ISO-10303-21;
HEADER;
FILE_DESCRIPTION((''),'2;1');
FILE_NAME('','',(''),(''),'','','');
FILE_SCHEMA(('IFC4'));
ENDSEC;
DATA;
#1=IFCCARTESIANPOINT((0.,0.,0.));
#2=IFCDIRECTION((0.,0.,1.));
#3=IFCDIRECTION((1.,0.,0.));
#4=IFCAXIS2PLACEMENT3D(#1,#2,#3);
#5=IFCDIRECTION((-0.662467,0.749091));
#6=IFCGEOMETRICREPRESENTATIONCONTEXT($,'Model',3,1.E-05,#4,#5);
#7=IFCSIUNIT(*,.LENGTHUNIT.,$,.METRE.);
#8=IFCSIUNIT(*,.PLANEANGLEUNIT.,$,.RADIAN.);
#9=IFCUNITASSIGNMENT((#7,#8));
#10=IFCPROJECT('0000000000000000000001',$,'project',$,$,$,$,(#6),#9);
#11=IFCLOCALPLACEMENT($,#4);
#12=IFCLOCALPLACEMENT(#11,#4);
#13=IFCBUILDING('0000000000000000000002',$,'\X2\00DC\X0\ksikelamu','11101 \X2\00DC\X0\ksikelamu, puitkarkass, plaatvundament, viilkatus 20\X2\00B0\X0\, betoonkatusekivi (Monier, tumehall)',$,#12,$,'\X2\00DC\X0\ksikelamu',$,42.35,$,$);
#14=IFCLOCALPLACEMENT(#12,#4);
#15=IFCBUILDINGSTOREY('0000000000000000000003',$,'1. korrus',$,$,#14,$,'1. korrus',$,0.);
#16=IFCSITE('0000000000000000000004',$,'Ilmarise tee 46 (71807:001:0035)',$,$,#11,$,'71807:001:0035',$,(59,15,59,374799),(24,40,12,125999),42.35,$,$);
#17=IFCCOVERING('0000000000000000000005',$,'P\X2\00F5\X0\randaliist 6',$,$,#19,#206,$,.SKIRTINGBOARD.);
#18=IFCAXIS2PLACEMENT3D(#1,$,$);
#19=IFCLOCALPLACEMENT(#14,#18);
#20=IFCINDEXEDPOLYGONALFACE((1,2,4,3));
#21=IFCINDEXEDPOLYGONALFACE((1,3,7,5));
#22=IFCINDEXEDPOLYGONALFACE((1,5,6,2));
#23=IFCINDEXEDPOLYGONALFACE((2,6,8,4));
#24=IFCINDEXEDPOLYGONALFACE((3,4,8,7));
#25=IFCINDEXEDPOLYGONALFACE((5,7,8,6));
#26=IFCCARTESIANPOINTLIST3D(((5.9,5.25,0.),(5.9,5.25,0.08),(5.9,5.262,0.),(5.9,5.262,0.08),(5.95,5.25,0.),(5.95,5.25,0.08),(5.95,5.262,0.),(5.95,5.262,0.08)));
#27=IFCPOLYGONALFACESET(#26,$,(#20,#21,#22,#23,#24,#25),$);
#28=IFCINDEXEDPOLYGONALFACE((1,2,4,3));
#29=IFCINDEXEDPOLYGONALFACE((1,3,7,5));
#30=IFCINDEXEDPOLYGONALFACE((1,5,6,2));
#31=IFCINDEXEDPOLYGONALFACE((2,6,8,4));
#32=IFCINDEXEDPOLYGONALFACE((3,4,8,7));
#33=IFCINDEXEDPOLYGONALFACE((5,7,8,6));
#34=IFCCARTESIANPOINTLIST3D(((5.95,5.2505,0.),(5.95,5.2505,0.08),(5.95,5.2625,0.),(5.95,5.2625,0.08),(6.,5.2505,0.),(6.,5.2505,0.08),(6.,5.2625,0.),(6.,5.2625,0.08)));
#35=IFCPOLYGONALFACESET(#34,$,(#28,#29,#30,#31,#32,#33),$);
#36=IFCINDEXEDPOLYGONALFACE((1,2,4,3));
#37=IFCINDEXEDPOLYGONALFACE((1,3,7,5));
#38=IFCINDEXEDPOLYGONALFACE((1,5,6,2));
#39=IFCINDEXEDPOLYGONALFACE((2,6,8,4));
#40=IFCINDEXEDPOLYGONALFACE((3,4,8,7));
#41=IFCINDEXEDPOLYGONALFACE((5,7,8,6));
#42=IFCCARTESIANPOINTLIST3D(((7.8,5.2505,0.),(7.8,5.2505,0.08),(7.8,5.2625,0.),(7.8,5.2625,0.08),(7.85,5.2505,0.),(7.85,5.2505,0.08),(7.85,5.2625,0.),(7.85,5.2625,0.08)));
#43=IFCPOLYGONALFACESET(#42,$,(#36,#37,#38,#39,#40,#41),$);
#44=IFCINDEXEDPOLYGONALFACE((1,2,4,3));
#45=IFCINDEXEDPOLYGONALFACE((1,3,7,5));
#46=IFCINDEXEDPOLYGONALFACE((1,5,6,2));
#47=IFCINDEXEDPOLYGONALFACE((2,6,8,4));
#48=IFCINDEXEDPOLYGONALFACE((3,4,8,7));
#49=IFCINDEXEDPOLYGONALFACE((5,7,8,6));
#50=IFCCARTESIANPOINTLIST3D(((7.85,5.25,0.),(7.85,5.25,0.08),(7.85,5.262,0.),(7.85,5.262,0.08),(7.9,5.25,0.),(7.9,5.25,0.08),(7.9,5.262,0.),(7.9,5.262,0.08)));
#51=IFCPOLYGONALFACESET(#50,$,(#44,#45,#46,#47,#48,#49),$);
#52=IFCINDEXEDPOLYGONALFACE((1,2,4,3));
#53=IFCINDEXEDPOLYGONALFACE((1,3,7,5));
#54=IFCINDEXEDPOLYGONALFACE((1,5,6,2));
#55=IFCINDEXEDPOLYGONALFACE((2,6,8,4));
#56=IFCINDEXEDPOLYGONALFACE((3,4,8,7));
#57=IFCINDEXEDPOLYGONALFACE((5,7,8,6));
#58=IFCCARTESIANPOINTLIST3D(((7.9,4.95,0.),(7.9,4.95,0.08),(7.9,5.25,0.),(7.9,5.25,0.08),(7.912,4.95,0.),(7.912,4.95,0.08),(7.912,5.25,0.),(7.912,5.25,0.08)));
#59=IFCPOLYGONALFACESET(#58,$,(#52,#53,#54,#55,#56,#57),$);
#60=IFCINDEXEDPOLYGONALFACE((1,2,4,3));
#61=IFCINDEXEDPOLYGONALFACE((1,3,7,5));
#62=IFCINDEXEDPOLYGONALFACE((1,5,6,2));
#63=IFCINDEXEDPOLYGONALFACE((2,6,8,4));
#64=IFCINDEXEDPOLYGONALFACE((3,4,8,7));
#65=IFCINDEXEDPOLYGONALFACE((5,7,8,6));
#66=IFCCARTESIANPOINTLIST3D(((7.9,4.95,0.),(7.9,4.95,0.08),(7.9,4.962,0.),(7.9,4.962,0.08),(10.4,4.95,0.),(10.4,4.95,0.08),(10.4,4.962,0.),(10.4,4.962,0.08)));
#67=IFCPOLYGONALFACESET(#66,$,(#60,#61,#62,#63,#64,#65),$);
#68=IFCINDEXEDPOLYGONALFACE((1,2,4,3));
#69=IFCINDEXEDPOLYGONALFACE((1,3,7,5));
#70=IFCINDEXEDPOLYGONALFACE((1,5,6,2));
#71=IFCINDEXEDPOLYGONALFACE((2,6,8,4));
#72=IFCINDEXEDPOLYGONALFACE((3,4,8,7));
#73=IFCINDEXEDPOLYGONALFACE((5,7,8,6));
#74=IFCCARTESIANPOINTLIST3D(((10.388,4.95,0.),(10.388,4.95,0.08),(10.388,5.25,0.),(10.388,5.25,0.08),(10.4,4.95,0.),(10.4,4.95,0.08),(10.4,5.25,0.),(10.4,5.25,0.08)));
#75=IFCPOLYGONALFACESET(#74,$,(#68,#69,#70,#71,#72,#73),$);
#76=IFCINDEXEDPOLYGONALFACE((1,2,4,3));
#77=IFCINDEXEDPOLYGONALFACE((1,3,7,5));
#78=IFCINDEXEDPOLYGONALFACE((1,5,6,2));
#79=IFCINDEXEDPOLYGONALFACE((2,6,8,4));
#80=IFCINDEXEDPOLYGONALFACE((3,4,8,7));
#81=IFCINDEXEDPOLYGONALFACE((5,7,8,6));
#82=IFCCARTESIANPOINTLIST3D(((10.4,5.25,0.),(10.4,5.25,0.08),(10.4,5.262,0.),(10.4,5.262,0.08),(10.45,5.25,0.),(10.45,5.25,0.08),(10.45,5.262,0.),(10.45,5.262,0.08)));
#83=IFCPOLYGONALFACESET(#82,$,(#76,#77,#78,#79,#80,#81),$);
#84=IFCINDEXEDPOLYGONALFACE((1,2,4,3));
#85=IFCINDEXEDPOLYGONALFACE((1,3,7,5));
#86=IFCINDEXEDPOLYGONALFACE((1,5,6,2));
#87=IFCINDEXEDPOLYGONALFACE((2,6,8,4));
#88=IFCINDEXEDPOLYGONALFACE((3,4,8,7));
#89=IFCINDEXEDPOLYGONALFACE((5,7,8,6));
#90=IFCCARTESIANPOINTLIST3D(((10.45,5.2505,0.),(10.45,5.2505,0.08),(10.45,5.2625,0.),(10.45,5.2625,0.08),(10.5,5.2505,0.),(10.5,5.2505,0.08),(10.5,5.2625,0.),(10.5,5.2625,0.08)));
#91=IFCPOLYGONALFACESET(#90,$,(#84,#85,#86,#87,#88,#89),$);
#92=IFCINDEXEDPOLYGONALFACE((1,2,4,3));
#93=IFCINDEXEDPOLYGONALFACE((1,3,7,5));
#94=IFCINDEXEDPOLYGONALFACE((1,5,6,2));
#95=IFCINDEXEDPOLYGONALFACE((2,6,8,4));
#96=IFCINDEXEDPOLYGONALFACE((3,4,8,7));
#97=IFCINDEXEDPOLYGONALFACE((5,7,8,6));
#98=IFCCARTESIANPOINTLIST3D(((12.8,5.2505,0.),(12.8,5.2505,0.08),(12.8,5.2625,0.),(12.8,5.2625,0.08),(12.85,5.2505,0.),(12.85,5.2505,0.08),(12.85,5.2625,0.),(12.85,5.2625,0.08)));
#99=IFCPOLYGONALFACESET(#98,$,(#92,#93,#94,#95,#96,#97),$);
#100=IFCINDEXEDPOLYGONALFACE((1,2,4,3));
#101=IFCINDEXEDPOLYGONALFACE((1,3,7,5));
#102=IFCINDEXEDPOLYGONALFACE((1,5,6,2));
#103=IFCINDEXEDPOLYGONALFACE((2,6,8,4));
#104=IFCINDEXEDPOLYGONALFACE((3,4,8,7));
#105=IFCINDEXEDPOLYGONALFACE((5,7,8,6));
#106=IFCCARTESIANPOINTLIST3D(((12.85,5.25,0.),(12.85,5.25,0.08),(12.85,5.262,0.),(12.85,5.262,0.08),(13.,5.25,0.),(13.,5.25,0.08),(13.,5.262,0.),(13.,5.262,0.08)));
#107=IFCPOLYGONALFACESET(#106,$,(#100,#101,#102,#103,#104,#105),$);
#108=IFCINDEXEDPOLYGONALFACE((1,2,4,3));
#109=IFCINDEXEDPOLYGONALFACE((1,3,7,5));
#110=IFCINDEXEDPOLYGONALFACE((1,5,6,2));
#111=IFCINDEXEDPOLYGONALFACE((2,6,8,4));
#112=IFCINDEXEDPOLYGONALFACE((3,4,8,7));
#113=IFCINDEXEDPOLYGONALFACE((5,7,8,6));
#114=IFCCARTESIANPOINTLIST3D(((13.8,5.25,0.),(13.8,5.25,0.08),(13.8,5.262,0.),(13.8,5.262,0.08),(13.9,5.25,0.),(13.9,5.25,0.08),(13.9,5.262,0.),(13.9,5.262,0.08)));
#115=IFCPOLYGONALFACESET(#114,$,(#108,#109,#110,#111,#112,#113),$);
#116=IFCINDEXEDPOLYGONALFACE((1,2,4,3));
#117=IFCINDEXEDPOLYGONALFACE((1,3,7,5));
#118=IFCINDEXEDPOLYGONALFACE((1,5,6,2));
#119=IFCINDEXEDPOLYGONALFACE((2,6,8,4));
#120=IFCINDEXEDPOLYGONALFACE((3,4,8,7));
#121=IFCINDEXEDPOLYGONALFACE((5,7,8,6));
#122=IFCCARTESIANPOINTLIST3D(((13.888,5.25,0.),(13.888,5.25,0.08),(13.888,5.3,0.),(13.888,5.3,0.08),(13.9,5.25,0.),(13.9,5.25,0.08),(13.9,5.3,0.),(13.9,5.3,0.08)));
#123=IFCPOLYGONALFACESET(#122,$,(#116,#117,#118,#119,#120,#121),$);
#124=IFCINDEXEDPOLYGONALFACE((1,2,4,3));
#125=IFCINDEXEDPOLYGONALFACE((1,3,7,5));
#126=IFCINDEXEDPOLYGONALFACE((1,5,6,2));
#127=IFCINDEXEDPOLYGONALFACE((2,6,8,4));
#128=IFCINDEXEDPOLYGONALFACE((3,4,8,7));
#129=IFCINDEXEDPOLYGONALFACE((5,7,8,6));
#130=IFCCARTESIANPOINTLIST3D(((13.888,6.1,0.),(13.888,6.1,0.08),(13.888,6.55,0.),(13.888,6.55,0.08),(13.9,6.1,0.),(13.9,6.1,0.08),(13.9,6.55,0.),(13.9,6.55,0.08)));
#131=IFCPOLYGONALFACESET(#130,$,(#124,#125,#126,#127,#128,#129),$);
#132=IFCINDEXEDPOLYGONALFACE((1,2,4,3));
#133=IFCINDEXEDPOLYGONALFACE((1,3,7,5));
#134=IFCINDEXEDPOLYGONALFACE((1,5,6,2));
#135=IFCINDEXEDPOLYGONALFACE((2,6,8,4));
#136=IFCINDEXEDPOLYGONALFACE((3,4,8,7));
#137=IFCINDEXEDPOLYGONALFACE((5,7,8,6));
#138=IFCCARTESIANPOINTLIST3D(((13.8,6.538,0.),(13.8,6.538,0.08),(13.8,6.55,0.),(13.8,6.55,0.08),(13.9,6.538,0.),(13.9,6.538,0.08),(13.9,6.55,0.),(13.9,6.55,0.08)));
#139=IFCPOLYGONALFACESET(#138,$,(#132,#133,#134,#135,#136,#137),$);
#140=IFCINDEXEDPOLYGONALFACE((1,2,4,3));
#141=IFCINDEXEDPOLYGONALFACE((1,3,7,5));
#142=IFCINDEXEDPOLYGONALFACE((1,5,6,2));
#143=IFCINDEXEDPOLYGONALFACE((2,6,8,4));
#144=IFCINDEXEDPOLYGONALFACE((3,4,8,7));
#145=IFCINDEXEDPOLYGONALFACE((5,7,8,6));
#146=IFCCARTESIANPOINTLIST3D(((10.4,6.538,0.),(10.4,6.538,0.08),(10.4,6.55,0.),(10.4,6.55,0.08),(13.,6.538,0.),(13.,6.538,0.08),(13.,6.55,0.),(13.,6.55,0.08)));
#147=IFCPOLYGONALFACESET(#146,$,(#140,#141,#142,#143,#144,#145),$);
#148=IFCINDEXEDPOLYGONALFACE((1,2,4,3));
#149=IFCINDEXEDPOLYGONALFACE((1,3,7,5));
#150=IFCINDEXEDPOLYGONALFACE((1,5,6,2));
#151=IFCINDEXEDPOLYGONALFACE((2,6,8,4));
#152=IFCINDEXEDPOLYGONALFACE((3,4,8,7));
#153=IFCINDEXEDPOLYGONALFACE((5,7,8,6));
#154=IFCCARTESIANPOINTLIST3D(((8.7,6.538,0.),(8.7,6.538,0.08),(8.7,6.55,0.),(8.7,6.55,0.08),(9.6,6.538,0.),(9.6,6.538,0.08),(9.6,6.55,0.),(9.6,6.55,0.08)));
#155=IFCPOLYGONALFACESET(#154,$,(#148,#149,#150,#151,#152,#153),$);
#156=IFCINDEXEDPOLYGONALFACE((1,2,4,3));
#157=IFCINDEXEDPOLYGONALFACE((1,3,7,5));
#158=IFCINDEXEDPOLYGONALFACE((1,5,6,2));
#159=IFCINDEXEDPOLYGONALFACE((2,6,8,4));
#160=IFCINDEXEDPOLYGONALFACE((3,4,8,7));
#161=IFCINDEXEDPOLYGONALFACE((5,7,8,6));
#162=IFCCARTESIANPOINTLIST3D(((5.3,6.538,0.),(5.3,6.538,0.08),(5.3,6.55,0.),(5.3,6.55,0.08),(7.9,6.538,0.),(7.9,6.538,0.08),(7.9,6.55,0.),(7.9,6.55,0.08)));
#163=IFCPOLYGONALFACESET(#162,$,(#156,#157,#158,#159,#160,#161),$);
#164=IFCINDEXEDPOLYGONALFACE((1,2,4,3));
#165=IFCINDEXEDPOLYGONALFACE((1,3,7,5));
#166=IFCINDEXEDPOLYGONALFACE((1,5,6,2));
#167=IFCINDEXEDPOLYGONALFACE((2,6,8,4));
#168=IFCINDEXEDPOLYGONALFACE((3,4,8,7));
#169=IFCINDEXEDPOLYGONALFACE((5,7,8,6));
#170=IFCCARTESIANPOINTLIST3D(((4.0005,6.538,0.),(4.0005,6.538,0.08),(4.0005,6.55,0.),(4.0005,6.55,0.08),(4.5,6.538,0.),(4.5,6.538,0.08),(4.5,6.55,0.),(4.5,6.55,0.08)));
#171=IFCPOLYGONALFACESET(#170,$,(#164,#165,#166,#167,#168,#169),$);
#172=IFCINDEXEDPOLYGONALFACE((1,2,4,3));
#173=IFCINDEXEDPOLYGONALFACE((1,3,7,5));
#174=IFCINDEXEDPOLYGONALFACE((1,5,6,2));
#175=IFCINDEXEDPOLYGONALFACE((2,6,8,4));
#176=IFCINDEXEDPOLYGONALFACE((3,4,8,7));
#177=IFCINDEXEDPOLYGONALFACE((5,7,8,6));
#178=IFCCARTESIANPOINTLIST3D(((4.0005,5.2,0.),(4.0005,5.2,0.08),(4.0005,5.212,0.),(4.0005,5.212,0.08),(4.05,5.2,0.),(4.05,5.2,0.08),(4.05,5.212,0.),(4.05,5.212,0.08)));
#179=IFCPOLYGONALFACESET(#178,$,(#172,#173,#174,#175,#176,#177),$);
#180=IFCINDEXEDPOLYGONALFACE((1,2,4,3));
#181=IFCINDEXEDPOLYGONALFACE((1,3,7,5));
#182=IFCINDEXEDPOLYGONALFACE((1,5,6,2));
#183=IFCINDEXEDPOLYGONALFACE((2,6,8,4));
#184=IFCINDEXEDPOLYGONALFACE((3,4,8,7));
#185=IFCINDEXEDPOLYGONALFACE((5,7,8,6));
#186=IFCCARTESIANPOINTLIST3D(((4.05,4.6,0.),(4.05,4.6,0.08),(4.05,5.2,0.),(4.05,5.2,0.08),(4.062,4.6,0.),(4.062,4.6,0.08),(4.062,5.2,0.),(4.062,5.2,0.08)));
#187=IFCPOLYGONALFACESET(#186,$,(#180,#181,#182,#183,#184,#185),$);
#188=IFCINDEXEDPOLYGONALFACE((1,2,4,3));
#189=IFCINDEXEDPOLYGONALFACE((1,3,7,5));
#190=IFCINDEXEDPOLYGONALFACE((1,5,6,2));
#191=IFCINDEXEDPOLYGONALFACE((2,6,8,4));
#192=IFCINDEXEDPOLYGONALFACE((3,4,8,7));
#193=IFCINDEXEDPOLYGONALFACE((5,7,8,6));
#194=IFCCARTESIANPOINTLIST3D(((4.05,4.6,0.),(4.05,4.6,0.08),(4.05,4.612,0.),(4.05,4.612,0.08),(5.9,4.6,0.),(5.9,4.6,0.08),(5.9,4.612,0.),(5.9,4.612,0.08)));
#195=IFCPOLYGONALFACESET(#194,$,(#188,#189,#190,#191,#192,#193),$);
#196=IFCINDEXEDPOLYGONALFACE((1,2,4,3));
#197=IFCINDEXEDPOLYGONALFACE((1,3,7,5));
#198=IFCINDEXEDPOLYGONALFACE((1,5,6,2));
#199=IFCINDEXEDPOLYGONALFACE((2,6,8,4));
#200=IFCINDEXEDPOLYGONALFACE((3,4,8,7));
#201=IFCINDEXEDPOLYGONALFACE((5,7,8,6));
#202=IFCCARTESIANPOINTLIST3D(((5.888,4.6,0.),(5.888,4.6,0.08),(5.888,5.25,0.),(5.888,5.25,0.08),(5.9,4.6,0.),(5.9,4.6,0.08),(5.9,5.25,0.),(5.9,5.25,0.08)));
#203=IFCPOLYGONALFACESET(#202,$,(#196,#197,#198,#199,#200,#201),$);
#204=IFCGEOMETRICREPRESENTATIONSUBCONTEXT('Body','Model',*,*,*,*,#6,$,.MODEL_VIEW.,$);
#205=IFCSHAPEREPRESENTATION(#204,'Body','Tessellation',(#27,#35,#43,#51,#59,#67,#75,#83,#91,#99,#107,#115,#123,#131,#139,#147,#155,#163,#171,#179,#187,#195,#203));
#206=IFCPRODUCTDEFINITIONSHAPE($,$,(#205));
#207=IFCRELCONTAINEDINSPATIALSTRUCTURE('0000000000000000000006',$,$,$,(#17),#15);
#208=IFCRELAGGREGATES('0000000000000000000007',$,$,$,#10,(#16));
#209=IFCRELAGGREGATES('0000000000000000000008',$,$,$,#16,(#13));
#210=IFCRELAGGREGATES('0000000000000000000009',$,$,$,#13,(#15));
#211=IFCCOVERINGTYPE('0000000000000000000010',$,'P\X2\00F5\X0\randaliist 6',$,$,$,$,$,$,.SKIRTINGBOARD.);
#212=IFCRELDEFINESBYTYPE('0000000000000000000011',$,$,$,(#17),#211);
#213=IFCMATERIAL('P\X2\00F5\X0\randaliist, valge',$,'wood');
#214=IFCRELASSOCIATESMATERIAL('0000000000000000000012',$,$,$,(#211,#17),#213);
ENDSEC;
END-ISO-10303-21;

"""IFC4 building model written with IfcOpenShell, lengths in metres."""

from ifc_helpers import new_model, si_unit, direction, origin_with_axes, place, context, subcontext, project, spatial, indexed_curve, outline, extrude, material, type_object, element, save


model = new_model("IFC4")

# Units and contexts
model_context = context("Model", 3, precision=1e-05, world=origin_with_axes(), true_north=direction((-0.662467, 0.749091)))
body_context = subcontext(model_context, "Body", "Model", "MODEL_VIEW")
ifc_project = project(units=[si_unit("LENGTHUNIT", "METRE"), si_unit("PLANEANGLEUNIT", "RADIAN")], contexts=[model_context])

# Site, building, storey
site_placement = place(None, origin_with_axes())
site = spatial("IfcSite", under=ifc_project, at=site_placement, Name="Ilmarise tee 46 (71807:001:0035)", LongName="71807:001:0035", RefLatitude=(59, 15, 59, 374799), RefLongitude=(24, 40, 12, 125999), RefElevation=42.35)
building_placement = place(site_placement, origin_with_axes())
building = spatial("IfcBuilding", under=site, at=building_placement, Name="Üksikelamu", Description="11101 Üksikelamu, puitkarkass, plaatvundament, viilkatus 20°, betoonkatusekivi (Monier, tumehall)", LongName="Üksikelamu", ElevationOfRefHeight=42.35)
storey_placement = place(building_placement, origin_with_axes())
storey = spatial("IfcBuildingStorey", under=building, at=storey_placement, Name="1. korrus", LongName="1. korrus", Elevation=0.0)

# Covering
ifc_material_1 = material(Name="Põrandaliist, valge", Category="wood")
covering_type_1 = type_object("IfcCoveringType", Name="Põrandaliist 6", PredefinedType="SKIRTINGBOARD", material=ifc_material_1)
covering_1_placement = place(storey_placement, origin_with_axes())
element("IfcCovering", 1, at=covering_1_placement, inside=storey, type_object=covering_type_1, material=ifc_material_1, Name="Põrandaliist 6", PredefinedType="SKIRTINGBOARD", context=body_context, shape_type="SweptSolid", body=[
    extrude(outline(indexed_curve([(5.9, 5.262), (5.95, 5.262), (5.95, 5.25), (5.9, 5.25), (5.9, 5.262)], self_intersect=False)), origin_with_axes(), (0.0, 0.0, 1.0), 0.08),
    extrude(outline(indexed_curve([(6.0, 5.2625), (6.0, 5.2505), (5.95, 5.2505), (5.95, 5.2625), (6.0, 5.2625)], self_intersect=False)), origin_with_axes(), (0.0, 0.0, 1.0), 0.08),
    extrude(outline(indexed_curve([(7.85, 5.2625), (7.85, 5.2505), (7.8, 5.2505), (7.8, 5.2625), (7.85, 5.2625)], self_intersect=False)), origin_with_axes(), (0.0, 0.0, 1.0), 0.08),
    extrude(outline(indexed_curve([(7.85, 5.262), (7.9, 5.262), (7.9, 5.25), (7.85, 5.25), (7.85, 5.262)], self_intersect=False)), origin_with_axes(), (0.0, 0.0, 1.0), 0.08),
    extrude(outline(indexed_curve([(7.912, 5.25), (7.912, 4.95), (7.9, 4.95), (7.9, 5.25), (7.912, 5.25)], self_intersect=False)), origin_with_axes(), (0.0, 0.0, 1.0), 0.08),
    extrude(outline(indexed_curve([(7.9, 4.962), (10.4, 4.962), (10.4, 4.95), (7.9, 4.95), (7.9, 4.962)], self_intersect=False)), origin_with_axes(), (0.0, 0.0, 1.0), 0.08),
    extrude(outline(indexed_curve([(10.388, 4.95), (10.388, 5.25), (10.4, 5.25), (10.4, 4.95), (10.388, 4.95)], self_intersect=False)), origin_with_axes(), (0.0, 0.0, 1.0), 0.08),
    extrude(outline(indexed_curve([(10.4, 5.262), (10.45, 5.262), (10.45, 5.25), (10.4, 5.25), (10.4, 5.262)], self_intersect=False)), origin_with_axes(), (0.0, 0.0, 1.0), 0.08),
    extrude(outline(indexed_curve([(10.5, 5.2625), (10.5, 5.2505), (10.45, 5.2505), (10.45, 5.2625), (10.5, 5.2625)], self_intersect=False)), origin_with_axes(), (0.0, 0.0, 1.0), 0.08),
    extrude(outline(indexed_curve([(12.85, 5.2625), (12.85, 5.2505), (12.8, 5.2505), (12.8, 5.2625), (12.85, 5.2625)], self_intersect=False)), origin_with_axes(), (0.0, 0.0, 1.0), 0.08),
    extrude(outline(indexed_curve([(12.85, 5.25), (12.85, 5.262), (13.0, 5.262), (13.0, 5.25), (12.85, 5.25)], self_intersect=False)), origin_with_axes(), (0.0, 0.0, 1.0), 0.08),
    extrude(outline(indexed_curve([(13.9, 5.262), (13.9, 5.25), (13.8, 5.25), (13.8, 5.262), (13.9, 5.262)], self_intersect=False)), origin_with_axes(), (0.0, 0.0, 1.0), 0.08),
    extrude(outline(indexed_curve([(13.9, 5.25), (13.888, 5.25), (13.888, 5.3), (13.9, 5.3), (13.9, 5.25)], self_intersect=False)), origin_with_axes(), (0.0, 0.0, 1.0), 0.08),
    extrude(outline(indexed_curve([(13.888, 6.55), (13.9, 6.55), (13.9, 6.1), (13.888, 6.1), (13.888, 6.55)], self_intersect=False)), origin_with_axes(), (0.0, 0.0, 1.0), 0.08),
    extrude(outline(indexed_curve([(13.9, 6.55), (13.9, 6.538), (13.8, 6.538), (13.8, 6.55), (13.9, 6.55)], self_intersect=False)), origin_with_axes(), (0.0, 0.0, 1.0), 0.08),
    extrude(outline(indexed_curve([(13.0, 6.55), (13.0, 6.538), (10.4, 6.538), (10.4, 6.55), (13.0, 6.55)], self_intersect=False)), origin_with_axes(), (0.0, 0.0, 1.0), 0.08),
    extrude(outline(indexed_curve([(9.6, 6.55), (9.6, 6.538), (8.7, 6.538), (8.7, 6.55), (9.6, 6.55)], self_intersect=False)), origin_with_axes(), (0.0, 0.0, 1.0), 0.08),
    extrude(outline(indexed_curve([(7.9, 6.55), (7.9, 6.538), (5.3, 6.538), (5.3, 6.55), (7.9, 6.55)], self_intersect=False)), origin_with_axes(), (0.0, 0.0, 1.0), 0.08),
    extrude(outline(indexed_curve([(4.0005, 6.538), (4.0005, 6.55), (4.5, 6.55), (4.5, 6.538), (4.0005, 6.538)], self_intersect=False)), origin_with_axes(), (0.0, 0.0, 1.0), 0.08),
    extrude(outline(indexed_curve([(4.0005, 5.212), (4.05, 5.212), (4.05, 5.2), (4.0005, 5.2), (4.0005, 5.212)], self_intersect=False)), origin_with_axes(), (0.0, 0.0, 1.0), 0.08),
    extrude(outline(indexed_curve([(4.062, 5.2), (4.062, 4.6), (4.05, 4.6), (4.05, 5.2), (4.062, 5.2)], self_intersect=False)), origin_with_axes(), (0.0, 0.0, 1.0), 0.08),
    extrude(outline(indexed_curve([(4.05, 4.612), (5.9, 4.612), (5.9, 4.6), (4.05, 4.6), (4.05, 4.612)], self_intersect=False)), origin_with_axes(), (0.0, 0.0, 1.0), 0.08),
    extrude(outline(indexed_curve([(5.888, 4.6), (5.888, 5.25), (5.9, 5.25), (5.9, 4.6), (5.888, 4.6)], self_intersect=False)), origin_with_axes(), (0.0, 0.0, 1.0), 0.08),
])

save(model, "model.ifc")
